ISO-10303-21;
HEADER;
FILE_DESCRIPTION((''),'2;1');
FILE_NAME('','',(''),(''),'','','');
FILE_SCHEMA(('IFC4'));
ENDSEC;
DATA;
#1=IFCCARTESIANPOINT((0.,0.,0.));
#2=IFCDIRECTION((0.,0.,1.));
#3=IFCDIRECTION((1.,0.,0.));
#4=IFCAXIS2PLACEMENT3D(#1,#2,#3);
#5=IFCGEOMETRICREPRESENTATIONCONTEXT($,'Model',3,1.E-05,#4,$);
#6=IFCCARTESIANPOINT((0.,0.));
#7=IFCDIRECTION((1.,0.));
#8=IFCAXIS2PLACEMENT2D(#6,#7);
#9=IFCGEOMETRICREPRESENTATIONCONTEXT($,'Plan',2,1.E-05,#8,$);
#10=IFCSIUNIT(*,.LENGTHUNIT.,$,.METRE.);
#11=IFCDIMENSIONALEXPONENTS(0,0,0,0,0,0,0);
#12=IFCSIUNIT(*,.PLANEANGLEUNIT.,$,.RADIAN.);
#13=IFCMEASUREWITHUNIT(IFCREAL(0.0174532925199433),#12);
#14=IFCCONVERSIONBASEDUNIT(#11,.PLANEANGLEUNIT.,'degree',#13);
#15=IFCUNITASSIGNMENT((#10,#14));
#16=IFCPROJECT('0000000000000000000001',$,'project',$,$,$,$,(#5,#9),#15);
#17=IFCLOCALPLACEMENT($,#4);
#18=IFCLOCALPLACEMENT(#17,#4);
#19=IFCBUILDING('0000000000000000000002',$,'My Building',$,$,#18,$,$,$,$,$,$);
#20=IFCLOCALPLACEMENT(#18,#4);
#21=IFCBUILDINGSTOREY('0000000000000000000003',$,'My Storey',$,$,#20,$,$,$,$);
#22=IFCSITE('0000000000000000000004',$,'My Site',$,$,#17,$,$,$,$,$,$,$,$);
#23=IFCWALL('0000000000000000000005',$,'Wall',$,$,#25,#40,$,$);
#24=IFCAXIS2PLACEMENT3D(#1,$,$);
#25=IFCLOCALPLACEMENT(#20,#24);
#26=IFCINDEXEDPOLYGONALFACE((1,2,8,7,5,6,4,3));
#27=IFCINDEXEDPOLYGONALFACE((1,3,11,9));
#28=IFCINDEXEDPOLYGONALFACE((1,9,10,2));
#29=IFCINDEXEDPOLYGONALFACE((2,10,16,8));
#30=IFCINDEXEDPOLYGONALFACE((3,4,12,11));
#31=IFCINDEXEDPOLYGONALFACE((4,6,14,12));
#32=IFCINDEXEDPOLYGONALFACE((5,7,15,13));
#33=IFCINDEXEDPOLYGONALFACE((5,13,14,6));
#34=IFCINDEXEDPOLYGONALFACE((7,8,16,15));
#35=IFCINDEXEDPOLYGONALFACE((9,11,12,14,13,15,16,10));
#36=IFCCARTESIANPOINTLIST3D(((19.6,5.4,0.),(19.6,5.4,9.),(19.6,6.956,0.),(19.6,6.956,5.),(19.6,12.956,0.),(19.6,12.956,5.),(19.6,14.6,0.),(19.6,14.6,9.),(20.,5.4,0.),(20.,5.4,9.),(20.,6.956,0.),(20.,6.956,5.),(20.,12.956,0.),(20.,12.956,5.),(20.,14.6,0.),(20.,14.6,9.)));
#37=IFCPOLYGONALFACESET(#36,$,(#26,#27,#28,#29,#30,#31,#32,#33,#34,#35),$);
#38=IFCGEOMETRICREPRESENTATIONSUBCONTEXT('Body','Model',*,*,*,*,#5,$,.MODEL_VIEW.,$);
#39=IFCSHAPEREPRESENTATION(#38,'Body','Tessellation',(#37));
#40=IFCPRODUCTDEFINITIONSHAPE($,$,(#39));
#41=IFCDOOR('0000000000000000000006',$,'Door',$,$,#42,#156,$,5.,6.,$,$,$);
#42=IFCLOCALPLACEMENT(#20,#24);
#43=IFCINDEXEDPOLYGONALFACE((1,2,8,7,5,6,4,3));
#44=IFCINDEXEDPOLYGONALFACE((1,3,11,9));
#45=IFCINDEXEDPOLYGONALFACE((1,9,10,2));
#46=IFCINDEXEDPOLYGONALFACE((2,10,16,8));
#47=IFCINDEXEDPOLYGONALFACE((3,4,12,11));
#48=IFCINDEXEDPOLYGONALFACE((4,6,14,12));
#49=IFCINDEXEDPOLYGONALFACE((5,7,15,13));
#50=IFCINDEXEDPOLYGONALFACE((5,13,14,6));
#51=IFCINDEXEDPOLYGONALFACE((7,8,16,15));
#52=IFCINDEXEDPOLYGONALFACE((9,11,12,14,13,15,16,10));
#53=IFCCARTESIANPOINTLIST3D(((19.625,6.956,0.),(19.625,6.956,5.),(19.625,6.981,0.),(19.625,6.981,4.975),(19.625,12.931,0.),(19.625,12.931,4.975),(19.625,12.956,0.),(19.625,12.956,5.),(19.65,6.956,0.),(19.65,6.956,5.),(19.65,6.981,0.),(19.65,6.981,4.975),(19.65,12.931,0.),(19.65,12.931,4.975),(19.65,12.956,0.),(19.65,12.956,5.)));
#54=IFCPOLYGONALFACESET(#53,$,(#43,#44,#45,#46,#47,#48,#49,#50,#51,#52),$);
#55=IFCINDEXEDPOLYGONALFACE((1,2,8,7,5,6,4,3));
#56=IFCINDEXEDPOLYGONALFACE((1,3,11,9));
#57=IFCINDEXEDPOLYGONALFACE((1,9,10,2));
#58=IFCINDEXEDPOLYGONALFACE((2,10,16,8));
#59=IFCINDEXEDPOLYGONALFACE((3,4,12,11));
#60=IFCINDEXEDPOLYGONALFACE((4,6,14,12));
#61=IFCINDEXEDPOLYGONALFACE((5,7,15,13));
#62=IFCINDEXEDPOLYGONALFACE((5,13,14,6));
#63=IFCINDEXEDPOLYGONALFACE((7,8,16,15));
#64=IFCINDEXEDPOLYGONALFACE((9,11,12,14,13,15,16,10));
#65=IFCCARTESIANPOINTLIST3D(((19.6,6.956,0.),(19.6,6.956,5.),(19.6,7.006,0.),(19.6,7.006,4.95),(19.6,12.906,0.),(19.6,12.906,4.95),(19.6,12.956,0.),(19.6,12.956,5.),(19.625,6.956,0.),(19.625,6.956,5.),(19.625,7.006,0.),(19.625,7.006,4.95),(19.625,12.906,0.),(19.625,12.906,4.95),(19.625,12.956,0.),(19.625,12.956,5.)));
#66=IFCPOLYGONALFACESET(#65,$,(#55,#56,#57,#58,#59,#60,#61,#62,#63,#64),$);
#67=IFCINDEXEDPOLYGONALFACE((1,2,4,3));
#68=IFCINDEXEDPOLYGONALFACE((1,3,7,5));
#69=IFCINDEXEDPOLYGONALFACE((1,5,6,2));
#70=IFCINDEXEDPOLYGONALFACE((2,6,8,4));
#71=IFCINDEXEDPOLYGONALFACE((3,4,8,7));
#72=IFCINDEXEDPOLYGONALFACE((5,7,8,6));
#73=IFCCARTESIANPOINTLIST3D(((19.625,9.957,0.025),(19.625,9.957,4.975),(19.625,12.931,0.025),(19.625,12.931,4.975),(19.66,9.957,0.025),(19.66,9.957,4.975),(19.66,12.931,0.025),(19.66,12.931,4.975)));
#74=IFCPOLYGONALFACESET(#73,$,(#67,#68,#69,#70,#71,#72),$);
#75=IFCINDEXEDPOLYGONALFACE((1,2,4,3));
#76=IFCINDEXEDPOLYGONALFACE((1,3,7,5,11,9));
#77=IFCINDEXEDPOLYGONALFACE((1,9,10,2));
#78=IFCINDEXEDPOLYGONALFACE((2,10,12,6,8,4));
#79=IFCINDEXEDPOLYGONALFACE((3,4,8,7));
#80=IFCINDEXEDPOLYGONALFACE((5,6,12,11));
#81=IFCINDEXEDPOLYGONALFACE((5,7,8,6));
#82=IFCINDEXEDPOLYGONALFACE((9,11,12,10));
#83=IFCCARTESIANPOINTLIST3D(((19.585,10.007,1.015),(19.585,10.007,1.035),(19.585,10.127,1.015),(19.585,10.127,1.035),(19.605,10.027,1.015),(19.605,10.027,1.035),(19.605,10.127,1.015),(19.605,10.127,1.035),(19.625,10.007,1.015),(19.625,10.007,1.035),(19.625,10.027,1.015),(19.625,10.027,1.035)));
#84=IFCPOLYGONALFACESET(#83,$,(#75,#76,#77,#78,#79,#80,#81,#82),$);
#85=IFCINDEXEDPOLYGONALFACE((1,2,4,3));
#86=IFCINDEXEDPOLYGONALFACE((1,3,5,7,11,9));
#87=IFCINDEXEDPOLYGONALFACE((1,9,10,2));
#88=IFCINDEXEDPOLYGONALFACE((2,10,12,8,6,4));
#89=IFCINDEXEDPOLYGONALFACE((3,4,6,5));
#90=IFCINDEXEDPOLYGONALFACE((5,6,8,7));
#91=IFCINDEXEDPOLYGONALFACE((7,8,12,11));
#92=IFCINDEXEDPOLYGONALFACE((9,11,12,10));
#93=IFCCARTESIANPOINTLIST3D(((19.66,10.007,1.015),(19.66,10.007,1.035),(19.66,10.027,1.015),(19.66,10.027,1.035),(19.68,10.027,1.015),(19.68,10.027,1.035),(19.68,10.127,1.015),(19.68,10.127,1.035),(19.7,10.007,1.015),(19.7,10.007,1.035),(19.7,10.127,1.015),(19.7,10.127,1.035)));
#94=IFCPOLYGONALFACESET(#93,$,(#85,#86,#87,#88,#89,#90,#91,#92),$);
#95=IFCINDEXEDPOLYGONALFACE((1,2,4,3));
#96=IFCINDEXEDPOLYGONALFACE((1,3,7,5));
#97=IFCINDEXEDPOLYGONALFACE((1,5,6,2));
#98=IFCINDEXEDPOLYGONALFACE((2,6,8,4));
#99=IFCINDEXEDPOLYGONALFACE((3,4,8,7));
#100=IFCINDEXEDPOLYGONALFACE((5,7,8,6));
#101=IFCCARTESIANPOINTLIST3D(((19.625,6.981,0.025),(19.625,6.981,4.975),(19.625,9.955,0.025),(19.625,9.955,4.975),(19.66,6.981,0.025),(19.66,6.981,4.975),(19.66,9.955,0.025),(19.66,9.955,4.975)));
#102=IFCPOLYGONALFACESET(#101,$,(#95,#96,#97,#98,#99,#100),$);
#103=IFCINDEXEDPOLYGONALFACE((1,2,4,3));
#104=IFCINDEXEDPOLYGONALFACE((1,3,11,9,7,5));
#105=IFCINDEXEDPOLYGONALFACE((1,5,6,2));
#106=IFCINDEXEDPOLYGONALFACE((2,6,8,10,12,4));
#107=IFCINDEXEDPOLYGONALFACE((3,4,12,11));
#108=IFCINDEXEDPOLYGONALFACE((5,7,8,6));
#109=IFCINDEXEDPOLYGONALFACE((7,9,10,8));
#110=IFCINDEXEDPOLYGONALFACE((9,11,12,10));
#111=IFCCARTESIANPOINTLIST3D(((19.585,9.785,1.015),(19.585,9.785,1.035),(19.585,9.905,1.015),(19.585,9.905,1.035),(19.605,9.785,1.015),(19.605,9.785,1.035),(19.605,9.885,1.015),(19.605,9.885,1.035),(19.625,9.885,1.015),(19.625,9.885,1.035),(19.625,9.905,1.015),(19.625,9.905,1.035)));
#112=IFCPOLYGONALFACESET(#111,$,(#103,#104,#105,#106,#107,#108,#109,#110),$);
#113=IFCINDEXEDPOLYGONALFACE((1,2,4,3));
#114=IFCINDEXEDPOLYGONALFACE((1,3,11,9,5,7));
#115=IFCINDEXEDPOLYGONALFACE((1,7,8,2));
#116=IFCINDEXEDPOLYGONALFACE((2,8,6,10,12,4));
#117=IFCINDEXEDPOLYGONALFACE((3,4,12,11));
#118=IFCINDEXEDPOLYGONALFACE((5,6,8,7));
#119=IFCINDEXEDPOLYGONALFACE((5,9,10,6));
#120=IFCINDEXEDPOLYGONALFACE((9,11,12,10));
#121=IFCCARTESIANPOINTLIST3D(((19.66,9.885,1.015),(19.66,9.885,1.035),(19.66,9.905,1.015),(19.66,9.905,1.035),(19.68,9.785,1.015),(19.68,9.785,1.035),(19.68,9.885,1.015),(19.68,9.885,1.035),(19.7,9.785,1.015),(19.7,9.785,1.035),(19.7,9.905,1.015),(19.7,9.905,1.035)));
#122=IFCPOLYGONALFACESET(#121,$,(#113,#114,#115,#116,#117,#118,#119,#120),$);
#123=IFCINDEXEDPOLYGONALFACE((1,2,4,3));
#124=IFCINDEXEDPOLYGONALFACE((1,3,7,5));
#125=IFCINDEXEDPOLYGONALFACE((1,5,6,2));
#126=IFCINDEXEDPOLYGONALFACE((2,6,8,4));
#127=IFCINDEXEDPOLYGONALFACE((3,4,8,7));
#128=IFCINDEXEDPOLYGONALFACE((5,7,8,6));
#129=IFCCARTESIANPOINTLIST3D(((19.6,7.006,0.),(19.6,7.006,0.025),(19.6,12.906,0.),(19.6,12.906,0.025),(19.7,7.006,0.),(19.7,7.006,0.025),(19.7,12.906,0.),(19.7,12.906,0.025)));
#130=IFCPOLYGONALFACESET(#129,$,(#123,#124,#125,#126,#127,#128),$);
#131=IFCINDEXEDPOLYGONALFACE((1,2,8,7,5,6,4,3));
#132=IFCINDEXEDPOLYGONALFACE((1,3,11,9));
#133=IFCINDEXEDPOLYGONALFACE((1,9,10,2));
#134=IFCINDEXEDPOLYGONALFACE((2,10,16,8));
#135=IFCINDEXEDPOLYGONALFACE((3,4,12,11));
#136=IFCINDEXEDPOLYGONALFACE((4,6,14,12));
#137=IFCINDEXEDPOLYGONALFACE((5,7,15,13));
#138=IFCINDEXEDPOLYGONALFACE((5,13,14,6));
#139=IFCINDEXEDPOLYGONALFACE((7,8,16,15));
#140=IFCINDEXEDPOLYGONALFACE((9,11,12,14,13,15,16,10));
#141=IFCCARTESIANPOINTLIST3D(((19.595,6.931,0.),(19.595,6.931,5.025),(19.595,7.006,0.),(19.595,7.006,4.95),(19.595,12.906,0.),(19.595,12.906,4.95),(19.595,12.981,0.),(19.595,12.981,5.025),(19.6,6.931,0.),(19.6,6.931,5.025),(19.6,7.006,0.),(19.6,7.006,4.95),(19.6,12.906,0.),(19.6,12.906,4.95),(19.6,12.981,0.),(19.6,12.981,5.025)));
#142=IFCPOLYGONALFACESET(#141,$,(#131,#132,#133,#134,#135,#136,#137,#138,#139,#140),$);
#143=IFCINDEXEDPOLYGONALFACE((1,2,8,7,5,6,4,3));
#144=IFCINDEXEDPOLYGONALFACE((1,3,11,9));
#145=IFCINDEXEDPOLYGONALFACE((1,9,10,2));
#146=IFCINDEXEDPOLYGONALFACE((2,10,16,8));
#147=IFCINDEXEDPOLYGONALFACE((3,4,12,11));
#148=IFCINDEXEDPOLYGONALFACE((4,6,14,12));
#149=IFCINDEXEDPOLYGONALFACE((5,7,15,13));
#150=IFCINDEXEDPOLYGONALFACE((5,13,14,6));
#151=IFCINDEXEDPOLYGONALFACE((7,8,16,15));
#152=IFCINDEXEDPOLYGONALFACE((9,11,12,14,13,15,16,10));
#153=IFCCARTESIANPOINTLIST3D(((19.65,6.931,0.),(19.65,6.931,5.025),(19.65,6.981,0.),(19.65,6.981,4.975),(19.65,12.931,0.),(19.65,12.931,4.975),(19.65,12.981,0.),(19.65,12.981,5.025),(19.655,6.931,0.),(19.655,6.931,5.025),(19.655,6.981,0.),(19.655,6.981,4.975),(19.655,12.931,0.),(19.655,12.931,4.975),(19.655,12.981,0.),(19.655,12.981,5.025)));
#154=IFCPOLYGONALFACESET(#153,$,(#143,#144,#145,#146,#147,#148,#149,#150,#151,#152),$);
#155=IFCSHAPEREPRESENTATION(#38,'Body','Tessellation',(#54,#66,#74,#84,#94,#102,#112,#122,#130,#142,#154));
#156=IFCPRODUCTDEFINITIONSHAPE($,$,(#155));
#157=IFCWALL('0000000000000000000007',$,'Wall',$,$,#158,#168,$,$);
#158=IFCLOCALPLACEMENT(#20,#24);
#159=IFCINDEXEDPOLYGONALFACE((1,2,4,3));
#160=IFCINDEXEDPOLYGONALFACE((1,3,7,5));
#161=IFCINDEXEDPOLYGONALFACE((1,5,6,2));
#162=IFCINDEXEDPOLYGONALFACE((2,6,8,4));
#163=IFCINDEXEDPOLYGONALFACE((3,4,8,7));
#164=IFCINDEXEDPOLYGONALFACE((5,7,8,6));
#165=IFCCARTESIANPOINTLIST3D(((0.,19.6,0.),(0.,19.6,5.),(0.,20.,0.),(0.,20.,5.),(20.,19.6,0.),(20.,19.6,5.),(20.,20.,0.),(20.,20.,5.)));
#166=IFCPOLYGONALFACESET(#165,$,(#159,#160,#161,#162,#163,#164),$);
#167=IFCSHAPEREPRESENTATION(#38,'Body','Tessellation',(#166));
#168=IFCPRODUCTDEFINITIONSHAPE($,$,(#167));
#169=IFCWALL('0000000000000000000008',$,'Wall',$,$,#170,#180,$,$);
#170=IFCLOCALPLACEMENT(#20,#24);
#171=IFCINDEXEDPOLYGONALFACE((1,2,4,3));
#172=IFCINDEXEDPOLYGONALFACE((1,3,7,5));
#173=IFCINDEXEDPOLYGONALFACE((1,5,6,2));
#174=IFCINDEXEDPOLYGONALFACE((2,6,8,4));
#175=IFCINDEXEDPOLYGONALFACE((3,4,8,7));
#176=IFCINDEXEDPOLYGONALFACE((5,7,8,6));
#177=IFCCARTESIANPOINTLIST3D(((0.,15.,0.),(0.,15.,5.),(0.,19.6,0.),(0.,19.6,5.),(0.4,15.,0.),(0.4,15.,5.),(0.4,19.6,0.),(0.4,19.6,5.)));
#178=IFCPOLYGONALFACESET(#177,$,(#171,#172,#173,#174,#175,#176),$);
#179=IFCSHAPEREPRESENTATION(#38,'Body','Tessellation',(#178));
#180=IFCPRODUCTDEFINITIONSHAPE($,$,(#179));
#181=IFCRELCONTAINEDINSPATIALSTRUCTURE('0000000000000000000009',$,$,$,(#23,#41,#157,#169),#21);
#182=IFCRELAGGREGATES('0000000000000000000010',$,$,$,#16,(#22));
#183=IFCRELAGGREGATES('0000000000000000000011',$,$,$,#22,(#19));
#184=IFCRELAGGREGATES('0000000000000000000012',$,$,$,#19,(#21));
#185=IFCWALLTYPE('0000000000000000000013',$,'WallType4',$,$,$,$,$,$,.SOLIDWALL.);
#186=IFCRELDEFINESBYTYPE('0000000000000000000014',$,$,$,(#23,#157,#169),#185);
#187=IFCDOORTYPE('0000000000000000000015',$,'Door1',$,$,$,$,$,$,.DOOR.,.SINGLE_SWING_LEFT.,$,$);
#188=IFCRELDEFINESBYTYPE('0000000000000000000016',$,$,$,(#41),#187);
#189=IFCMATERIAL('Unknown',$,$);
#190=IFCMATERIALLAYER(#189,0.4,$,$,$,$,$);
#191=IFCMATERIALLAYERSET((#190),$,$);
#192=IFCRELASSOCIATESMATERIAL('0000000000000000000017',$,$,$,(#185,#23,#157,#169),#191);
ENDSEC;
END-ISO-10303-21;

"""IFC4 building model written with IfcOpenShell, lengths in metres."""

from ifc_helpers import new_model, entity, si_unit, converted_unit, frame, origin_with_axes, origin_2d_with_axis, place, context, subcontext, project, spatial, line, indexed_curve, outline, extrude, shape, source, transform, mapped, material, layer, layer_set, layer_usage, type_object, type_shapes, element, fill, save


model = new_model("IFC4")

# Units and contexts
model_context = context("Model", 3, precision=1e-05, world=origin_with_axes())
plan_context = context("Plan", 2, precision=1e-05, world=origin_2d_with_axis())
body_context_1 = subcontext(model_context, "Body", "Model", "MODEL_VIEW")
body_context_2 = subcontext(plan_context, "Body", "Plan", "PLAN_VIEW")
ifc_project = project(units=[si_unit("LENGTHUNIT", "METRE"), converted_unit("PLANEANGLEUNIT", "degree", entity("IfcReal", 0.0174532925199433), si_unit("PLANEANGLEUNIT", "RADIAN"), dimensions=[0, 0, 0, 0, 0, 0, 0])], contexts=[model_context, plan_context])

# Site, building, storey
site_placement = place(None, origin_with_axes())
site = spatial("IfcSite", under=ifc_project, at=site_placement, Name="My Site")
building_placement = place(site_placement, origin_with_axes())
building = spatial("IfcBuilding", under=site, at=building_placement, Name="My Building")
storey_placement = place(building_placement, origin_with_axes())
storey = spatial("IfcBuildingStorey", under=building, at=storey_placement, Name="My Storey")

# Shared definitions
ifc_material = material(Name="Unknown")
ifc_layer = layer(ifc_material, 0.4)
ifc_layer_set = layer_set([ifc_layer])
wall_type = type_object("IfcWallType", Name="WallType4", PredefinedType="SOLIDWALL", material=ifc_layer_set)

# Wall, opening, door
shared_shape_1 = source(origin_with_axes(), body_context_1, "Body", "SweptSolid", [
    extrude(outline(indexed_curve([(0.0, 0.0), (6.0, 0.0), (6.0, 5.0), (0.0, 5.0)], segments=[line(1, 2, 3, 4, 1)])), frame((0.0, -0.1, 0.0), z_axis=(0.0, -1.0, 0.0), x_axis=(1.0, 0.0, 0.0)), (0.0, 0.0, -1.0), 0.6),
])
door_type = type_object("IfcDoorType", Name="Door1", OperationType="SINGLE_SWING_LEFT", PredefinedType="DOOR")
shared_shape_2 = source(origin_with_axes(), body_context_1, "Body", "SweptSolid", [
    extrude(outline(indexed_curve([(0.0, 0.0), (0.0, 5.0), (6.0, 5.0), (6.0, 0.0), (5.975, 0.0), (5.975, 4.975), (0.025, 4.975), (0.025, 0.0)], segments=[line(1, 2, 3, 4, 5, 6, 7, 8, 1)])), frame((0.0, 0.025, 0.0), z_axis=(0.0, -1.0, 0.0), x_axis=(1.0, 0.0, 0.0)), (0.0, 0.0, -1.0), 0.025),
    extrude(outline(indexed_curve([(0.0, 0.0), (0.0, 5.0), (6.0, 5.0), (6.0, 0.0), (5.95, 0.0), (5.95, 4.95), (0.05, 4.95), (0.05, 0.0)], segments=[line(1, 2, 3, 4, 5, 6, 7, 8, 1)])), frame((0.0, 0.0, 0.0), z_axis=(0.0, -1.0, 0.0), x_axis=(1.0, 0.0, 0.0)), (0.0, 0.0, -1.0), 0.025),
    extrude(outline(indexed_curve([(0.0, 0.0), (2.974, 0.0), (2.974, 0.035), (0.0, 0.035)], segments=[line(1, 2, 3, 4, 1)])), frame((0.025, 0.025, 0.025), z_axis=(0.0, 0.0, 1.0), x_axis=(1.0, 0.0, 0.0)), (0.0, 0.0, 1.0), 4.95),
    extrude(outline(indexed_curve([(0.0, 0.0), (0.0, -0.04), (-0.12, -0.04), (-0.12, -0.02), (-0.02, -0.02), (-0.02, 0.0)], segments=[line(1, 2, 3, 4, 5, 6, 1)])), frame((2.949, 0.025, 1.015), z_axis=(0.0, 0.0, 1.0), x_axis=(1.0, 0.0, 0.0)), (0.0, 0.0, 1.0), 0.02),
    extrude(outline(indexed_curve([(0.0, 0.0), (0.0, 0.04), (-0.12, 0.04), (-0.12, 0.02), (-0.02, 0.02), (-0.02, 0.0)], segments=[line(1, 2, 3, 4, 5, 6, 1)])), frame((2.949, 0.06, 1.015), z_axis=(0.0, 0.0, 1.0), x_axis=(1.0, 0.0, 0.0)), (0.0, 0.0, 1.0), 0.02),
    extrude(outline(indexed_curve([(0.0, 0.0), (-2.974, 0.0), (-2.974, 0.035), (0.0, 0.035)], segments=[line(1, 2, 3, 4, 1)])), frame((5.975, 0.025, 0.025), z_axis=(0.0, 0.0, 1.0), x_axis=(1.0, 0.0, 0.0)), (0.0, 0.0, 1.0), 4.95),
    extrude(outline(indexed_curve([(0.0, 0.0), (0.0, -0.04), (0.12, -0.04), (0.12, -0.02), (0.02, -0.02), (0.02, 0.0)], segments=[line(1, 2, 3, 4, 5, 6, 1)])), frame((3.051, 0.025, 1.015), z_axis=(0.0, 0.0, 1.0), x_axis=(1.0, 0.0, 0.0)), (0.0, 0.0, 1.0), 0.02),
    extrude(outline(indexed_curve([(0.0, 0.0), (0.0, 0.04), (0.12, 0.04), (0.12, 0.02), (0.02, 0.02), (0.02, 0.0)], segments=[line(1, 2, 3, 4, 5, 6, 1)])), frame((3.051, 0.06, 1.015), z_axis=(0.0, 0.0, 1.0), x_axis=(1.0, 0.0, 0.0)), (0.0, 0.0, 1.0), 0.02),
    extrude(outline(indexed_curve([(0.0, 0.0), (5.9, 0.0), (5.9, 0.1), (0.0, 0.1)], segments=[line(1, 2, 3, 4, 1)])), frame((0.05, 0.0, 0.0), z_axis=(0.0, 0.0, 1.0), x_axis=(1.0, 0.0, 0.0)), (0.0, 0.0, 1.0), 0.025),
    extrude(outline(indexed_curve([(0.0, 0.0), (0.0, 5.025), (6.05, 5.025), (6.05, 0.0), (5.975, 0.0), (5.975, 4.95), (0.075, 4.95), (0.075, 0.0)], segments=[line(1, 2, 3, 4, 5, 6, 7, 8, 1)])), frame((-0.025, -0.005, 0.0), z_axis=(0.0, -1.0, 0.0), x_axis=(1.0, 0.0, 0.0)), (0.0, 0.0, -1.0), 0.005),
    extrude(outline(indexed_curve([(0.0, 0.0), (0.0, 5.025), (6.05, 5.025), (6.05, 0.0), (6.0, 0.0), (6.0, 4.975), (0.05, 4.975), (0.05, 0.0)], segments=[line(1, 2, 3, 4, 5, 6, 7, 8, 1)])), frame((-0.025, 0.05, 0.0), z_axis=(0.0, -1.0, 0.0), x_axis=(1.0, 0.0, 0.0)), (0.0, 0.0, -1.0), 0.005),
])
shared_shape_3 = source(origin_with_axes(), body_context_2, "Body", "Curve2D", [
    entity("IfcIndexedPolyCurve", entity("IfcCartesianPointList2D", [[0.0, 0.0], [0.0, 0.05], [0.025, 0.05], [0.025, 0.025], [0.05, 0.025], [0.05, 0.0]]), [entity("IfcLineIndex", [1, 2, 3, 4, 5, 6, 1])]),
    entity("IfcIndexedPolyCurve", entity("IfcCartesianPointList2D", [[6.0, 0.0], [6.0, 0.05], [5.975, 0.05], [5.975, 0.025], [5.95, 0.025], [5.95, 0.0]]), [entity("IfcLineIndex", [1, 2, 3, 4, 5, 6, 1])]),
    entity("IfcTrimmedCurve", entity("IfcEllipse", entity("IfcAxis2Placement2D", entity("IfcCartesianPoint", [0.06, 0.05]), entity("IfcDirection", [1.0, 0.0])), 2.94, 2.975), [entity("IfcCartesianPoint", [3.0, 0.05])], [entity("IfcCartesianPoint", [0.06, 3.025])], True, "CARTESIAN"),
    entity("IfcIndexedPolyCurve", entity("IfcCartesianPointList2D", [[0.025, 0.05], [0.06, 0.05], [0.06, 3.025], [0.025, 3.025]]), [entity("IfcLineIndex", [1, 2, 3, 4, 1])]),
    entity("IfcTrimmedCurve", entity("IfcEllipse", entity("IfcAxis2Placement2D", entity("IfcCartesianPoint", [5.94, 0.05]), entity("IfcDirection", [1.0, 0.0])), 2.94, 2.975), [entity("IfcCartesianPoint", [5.94, 3.025])], [entity("IfcCartesianPoint", [3.0, 0.05])], True, "CARTESIAN"),
    entity("IfcIndexedPolyCurve", entity("IfcCartesianPointList2D", [[5.975, 0.05], [5.94, 0.05], [5.94, 3.025], [5.975, 3.025]]), [entity("IfcLineIndex", [1, 2, 3, 4, 1])]),
])
type_shapes(door_type, [shared_shape_2, shared_shape_3])
ifc_layer_usage_1 = layer_usage(ifc_layer_set, "AXIS2", "POSITIVE", 0.0)
wall_1_placement = place(storey_placement, frame((19.6, 14.6, 0.0), z_axis=(0.0, 0.0, 1.0), x_axis=(0.0, -1.0, 0.0)))
wall_1 = element("IfcWall", 1, at=wall_1_placement, inside=storey, type_object=wall_type, material=ifc_layer_usage_1, Name="Wall", context=body_context_1, shape_type="SweptSolid", body=[
    extrude(outline(indexed_curve([(0.0, 0.0), (0.0, 0.4), (9.2, 0.4), (9.2, 0.0), (0.0, 0.0)], self_intersect=False)), origin_with_axes(), (0.0, 0.0, 1.0), 9.0),
])
opening_1_placement = place(wall_1_placement, frame((1.644, 0.0, 0.0), z_axis=(0.0, 0.0, 1.0), x_axis=(1.0, 0.0, 0.0)))
opening_1 = element("IfcOpeningElement", 2, at=opening_1_placement, cuts=wall_1, PredefinedType="OPENING", context=body_context_1, shape_type="MappedRepresentation", body=[
    mapped(shared_shape_1, transform((0.0, 0.0, 0.0), x_axis=(1.0, 0.0, 0.0), y_axis=(0.0, 1.0, 0.0), z_axis=(0.0, 0.0, 1.0), scale=1.0)),
])
door_1_placement = place(opening_1_placement, origin_with_axes())
door_1 = element("IfcDoor", 3, at=door_1_placement, inside=storey, type_object=door_type, Name="Door", OverallHeight=5.0, OverallWidth=6.0, shapes=[
    shape(body_context_1, "Body", "MappedRepresentation", [mapped(shared_shape_2, transform((0.0, 0.0, 0.0), x_axis=(1.0, 0.0, 0.0), y_axis=(0.0, 1.0, 0.0), z_axis=(0.0, 0.0, 1.0), scale=1.0))]),
    shape(body_context_2, "Body", "MappedRepresentation", [mapped(shared_shape_3, transform((0.0, 0.0, 0.0), x_axis=(1.0, 0.0, 0.0), y_axis=(0.0, 1.0, 0.0), z_axis=(0.0, 0.0, 1.0), scale=1.0))]),
])
fill(opening_1, door_1)

# Walls
ifc_layer_usage_2 = layer_usage(ifc_layer_set, "AXIS2", "POSITIVE", 0.0)
wall_2_placement = place(storey_placement, frame((0.0, 19.6, 0.0), z_axis=(0.0, 0.0, 1.0), x_axis=(1.0, 0.0, 0.0)))
element("IfcWall", 4, at=wall_2_placement, inside=storey, type_object=wall_type, material=ifc_layer_usage_2, Name="Wall", context=body_context_1, shape_type="SweptSolid", body=[
    extrude(outline(indexed_curve([(0.0, 0.0), (0.0, 0.4), (20.0, 0.4), (20.0, 0.0), (0.0, 0.0)], self_intersect=False)), origin_with_axes(), (0.0, 0.0, 1.0), 5.0),
])
ifc_layer_usage_3 = layer_usage(ifc_layer_set, "AXIS2", "POSITIVE", 0.0)
wall_3_placement = place(storey_placement, frame((0.0, 19.6, 0.0), z_axis=(0.0, 0.0, 1.0), x_axis=(0.0, -1.0, 0.0)))
element("IfcWall", 5, at=wall_3_placement, inside=storey, type_object=wall_type, material=ifc_layer_usage_3, Name="Wall", context=body_context_1, shape_type="SweptSolid", body=[
    extrude(outline(indexed_curve([(0.0, 0.0), (0.0, 0.4), (4.6, 0.4), (4.6, 0.0), (0.0, 0.0)], self_intersect=False)), origin_with_axes(), (0.0, 0.0, 1.0), 5.0),
])

save(model, "model.ifc")
